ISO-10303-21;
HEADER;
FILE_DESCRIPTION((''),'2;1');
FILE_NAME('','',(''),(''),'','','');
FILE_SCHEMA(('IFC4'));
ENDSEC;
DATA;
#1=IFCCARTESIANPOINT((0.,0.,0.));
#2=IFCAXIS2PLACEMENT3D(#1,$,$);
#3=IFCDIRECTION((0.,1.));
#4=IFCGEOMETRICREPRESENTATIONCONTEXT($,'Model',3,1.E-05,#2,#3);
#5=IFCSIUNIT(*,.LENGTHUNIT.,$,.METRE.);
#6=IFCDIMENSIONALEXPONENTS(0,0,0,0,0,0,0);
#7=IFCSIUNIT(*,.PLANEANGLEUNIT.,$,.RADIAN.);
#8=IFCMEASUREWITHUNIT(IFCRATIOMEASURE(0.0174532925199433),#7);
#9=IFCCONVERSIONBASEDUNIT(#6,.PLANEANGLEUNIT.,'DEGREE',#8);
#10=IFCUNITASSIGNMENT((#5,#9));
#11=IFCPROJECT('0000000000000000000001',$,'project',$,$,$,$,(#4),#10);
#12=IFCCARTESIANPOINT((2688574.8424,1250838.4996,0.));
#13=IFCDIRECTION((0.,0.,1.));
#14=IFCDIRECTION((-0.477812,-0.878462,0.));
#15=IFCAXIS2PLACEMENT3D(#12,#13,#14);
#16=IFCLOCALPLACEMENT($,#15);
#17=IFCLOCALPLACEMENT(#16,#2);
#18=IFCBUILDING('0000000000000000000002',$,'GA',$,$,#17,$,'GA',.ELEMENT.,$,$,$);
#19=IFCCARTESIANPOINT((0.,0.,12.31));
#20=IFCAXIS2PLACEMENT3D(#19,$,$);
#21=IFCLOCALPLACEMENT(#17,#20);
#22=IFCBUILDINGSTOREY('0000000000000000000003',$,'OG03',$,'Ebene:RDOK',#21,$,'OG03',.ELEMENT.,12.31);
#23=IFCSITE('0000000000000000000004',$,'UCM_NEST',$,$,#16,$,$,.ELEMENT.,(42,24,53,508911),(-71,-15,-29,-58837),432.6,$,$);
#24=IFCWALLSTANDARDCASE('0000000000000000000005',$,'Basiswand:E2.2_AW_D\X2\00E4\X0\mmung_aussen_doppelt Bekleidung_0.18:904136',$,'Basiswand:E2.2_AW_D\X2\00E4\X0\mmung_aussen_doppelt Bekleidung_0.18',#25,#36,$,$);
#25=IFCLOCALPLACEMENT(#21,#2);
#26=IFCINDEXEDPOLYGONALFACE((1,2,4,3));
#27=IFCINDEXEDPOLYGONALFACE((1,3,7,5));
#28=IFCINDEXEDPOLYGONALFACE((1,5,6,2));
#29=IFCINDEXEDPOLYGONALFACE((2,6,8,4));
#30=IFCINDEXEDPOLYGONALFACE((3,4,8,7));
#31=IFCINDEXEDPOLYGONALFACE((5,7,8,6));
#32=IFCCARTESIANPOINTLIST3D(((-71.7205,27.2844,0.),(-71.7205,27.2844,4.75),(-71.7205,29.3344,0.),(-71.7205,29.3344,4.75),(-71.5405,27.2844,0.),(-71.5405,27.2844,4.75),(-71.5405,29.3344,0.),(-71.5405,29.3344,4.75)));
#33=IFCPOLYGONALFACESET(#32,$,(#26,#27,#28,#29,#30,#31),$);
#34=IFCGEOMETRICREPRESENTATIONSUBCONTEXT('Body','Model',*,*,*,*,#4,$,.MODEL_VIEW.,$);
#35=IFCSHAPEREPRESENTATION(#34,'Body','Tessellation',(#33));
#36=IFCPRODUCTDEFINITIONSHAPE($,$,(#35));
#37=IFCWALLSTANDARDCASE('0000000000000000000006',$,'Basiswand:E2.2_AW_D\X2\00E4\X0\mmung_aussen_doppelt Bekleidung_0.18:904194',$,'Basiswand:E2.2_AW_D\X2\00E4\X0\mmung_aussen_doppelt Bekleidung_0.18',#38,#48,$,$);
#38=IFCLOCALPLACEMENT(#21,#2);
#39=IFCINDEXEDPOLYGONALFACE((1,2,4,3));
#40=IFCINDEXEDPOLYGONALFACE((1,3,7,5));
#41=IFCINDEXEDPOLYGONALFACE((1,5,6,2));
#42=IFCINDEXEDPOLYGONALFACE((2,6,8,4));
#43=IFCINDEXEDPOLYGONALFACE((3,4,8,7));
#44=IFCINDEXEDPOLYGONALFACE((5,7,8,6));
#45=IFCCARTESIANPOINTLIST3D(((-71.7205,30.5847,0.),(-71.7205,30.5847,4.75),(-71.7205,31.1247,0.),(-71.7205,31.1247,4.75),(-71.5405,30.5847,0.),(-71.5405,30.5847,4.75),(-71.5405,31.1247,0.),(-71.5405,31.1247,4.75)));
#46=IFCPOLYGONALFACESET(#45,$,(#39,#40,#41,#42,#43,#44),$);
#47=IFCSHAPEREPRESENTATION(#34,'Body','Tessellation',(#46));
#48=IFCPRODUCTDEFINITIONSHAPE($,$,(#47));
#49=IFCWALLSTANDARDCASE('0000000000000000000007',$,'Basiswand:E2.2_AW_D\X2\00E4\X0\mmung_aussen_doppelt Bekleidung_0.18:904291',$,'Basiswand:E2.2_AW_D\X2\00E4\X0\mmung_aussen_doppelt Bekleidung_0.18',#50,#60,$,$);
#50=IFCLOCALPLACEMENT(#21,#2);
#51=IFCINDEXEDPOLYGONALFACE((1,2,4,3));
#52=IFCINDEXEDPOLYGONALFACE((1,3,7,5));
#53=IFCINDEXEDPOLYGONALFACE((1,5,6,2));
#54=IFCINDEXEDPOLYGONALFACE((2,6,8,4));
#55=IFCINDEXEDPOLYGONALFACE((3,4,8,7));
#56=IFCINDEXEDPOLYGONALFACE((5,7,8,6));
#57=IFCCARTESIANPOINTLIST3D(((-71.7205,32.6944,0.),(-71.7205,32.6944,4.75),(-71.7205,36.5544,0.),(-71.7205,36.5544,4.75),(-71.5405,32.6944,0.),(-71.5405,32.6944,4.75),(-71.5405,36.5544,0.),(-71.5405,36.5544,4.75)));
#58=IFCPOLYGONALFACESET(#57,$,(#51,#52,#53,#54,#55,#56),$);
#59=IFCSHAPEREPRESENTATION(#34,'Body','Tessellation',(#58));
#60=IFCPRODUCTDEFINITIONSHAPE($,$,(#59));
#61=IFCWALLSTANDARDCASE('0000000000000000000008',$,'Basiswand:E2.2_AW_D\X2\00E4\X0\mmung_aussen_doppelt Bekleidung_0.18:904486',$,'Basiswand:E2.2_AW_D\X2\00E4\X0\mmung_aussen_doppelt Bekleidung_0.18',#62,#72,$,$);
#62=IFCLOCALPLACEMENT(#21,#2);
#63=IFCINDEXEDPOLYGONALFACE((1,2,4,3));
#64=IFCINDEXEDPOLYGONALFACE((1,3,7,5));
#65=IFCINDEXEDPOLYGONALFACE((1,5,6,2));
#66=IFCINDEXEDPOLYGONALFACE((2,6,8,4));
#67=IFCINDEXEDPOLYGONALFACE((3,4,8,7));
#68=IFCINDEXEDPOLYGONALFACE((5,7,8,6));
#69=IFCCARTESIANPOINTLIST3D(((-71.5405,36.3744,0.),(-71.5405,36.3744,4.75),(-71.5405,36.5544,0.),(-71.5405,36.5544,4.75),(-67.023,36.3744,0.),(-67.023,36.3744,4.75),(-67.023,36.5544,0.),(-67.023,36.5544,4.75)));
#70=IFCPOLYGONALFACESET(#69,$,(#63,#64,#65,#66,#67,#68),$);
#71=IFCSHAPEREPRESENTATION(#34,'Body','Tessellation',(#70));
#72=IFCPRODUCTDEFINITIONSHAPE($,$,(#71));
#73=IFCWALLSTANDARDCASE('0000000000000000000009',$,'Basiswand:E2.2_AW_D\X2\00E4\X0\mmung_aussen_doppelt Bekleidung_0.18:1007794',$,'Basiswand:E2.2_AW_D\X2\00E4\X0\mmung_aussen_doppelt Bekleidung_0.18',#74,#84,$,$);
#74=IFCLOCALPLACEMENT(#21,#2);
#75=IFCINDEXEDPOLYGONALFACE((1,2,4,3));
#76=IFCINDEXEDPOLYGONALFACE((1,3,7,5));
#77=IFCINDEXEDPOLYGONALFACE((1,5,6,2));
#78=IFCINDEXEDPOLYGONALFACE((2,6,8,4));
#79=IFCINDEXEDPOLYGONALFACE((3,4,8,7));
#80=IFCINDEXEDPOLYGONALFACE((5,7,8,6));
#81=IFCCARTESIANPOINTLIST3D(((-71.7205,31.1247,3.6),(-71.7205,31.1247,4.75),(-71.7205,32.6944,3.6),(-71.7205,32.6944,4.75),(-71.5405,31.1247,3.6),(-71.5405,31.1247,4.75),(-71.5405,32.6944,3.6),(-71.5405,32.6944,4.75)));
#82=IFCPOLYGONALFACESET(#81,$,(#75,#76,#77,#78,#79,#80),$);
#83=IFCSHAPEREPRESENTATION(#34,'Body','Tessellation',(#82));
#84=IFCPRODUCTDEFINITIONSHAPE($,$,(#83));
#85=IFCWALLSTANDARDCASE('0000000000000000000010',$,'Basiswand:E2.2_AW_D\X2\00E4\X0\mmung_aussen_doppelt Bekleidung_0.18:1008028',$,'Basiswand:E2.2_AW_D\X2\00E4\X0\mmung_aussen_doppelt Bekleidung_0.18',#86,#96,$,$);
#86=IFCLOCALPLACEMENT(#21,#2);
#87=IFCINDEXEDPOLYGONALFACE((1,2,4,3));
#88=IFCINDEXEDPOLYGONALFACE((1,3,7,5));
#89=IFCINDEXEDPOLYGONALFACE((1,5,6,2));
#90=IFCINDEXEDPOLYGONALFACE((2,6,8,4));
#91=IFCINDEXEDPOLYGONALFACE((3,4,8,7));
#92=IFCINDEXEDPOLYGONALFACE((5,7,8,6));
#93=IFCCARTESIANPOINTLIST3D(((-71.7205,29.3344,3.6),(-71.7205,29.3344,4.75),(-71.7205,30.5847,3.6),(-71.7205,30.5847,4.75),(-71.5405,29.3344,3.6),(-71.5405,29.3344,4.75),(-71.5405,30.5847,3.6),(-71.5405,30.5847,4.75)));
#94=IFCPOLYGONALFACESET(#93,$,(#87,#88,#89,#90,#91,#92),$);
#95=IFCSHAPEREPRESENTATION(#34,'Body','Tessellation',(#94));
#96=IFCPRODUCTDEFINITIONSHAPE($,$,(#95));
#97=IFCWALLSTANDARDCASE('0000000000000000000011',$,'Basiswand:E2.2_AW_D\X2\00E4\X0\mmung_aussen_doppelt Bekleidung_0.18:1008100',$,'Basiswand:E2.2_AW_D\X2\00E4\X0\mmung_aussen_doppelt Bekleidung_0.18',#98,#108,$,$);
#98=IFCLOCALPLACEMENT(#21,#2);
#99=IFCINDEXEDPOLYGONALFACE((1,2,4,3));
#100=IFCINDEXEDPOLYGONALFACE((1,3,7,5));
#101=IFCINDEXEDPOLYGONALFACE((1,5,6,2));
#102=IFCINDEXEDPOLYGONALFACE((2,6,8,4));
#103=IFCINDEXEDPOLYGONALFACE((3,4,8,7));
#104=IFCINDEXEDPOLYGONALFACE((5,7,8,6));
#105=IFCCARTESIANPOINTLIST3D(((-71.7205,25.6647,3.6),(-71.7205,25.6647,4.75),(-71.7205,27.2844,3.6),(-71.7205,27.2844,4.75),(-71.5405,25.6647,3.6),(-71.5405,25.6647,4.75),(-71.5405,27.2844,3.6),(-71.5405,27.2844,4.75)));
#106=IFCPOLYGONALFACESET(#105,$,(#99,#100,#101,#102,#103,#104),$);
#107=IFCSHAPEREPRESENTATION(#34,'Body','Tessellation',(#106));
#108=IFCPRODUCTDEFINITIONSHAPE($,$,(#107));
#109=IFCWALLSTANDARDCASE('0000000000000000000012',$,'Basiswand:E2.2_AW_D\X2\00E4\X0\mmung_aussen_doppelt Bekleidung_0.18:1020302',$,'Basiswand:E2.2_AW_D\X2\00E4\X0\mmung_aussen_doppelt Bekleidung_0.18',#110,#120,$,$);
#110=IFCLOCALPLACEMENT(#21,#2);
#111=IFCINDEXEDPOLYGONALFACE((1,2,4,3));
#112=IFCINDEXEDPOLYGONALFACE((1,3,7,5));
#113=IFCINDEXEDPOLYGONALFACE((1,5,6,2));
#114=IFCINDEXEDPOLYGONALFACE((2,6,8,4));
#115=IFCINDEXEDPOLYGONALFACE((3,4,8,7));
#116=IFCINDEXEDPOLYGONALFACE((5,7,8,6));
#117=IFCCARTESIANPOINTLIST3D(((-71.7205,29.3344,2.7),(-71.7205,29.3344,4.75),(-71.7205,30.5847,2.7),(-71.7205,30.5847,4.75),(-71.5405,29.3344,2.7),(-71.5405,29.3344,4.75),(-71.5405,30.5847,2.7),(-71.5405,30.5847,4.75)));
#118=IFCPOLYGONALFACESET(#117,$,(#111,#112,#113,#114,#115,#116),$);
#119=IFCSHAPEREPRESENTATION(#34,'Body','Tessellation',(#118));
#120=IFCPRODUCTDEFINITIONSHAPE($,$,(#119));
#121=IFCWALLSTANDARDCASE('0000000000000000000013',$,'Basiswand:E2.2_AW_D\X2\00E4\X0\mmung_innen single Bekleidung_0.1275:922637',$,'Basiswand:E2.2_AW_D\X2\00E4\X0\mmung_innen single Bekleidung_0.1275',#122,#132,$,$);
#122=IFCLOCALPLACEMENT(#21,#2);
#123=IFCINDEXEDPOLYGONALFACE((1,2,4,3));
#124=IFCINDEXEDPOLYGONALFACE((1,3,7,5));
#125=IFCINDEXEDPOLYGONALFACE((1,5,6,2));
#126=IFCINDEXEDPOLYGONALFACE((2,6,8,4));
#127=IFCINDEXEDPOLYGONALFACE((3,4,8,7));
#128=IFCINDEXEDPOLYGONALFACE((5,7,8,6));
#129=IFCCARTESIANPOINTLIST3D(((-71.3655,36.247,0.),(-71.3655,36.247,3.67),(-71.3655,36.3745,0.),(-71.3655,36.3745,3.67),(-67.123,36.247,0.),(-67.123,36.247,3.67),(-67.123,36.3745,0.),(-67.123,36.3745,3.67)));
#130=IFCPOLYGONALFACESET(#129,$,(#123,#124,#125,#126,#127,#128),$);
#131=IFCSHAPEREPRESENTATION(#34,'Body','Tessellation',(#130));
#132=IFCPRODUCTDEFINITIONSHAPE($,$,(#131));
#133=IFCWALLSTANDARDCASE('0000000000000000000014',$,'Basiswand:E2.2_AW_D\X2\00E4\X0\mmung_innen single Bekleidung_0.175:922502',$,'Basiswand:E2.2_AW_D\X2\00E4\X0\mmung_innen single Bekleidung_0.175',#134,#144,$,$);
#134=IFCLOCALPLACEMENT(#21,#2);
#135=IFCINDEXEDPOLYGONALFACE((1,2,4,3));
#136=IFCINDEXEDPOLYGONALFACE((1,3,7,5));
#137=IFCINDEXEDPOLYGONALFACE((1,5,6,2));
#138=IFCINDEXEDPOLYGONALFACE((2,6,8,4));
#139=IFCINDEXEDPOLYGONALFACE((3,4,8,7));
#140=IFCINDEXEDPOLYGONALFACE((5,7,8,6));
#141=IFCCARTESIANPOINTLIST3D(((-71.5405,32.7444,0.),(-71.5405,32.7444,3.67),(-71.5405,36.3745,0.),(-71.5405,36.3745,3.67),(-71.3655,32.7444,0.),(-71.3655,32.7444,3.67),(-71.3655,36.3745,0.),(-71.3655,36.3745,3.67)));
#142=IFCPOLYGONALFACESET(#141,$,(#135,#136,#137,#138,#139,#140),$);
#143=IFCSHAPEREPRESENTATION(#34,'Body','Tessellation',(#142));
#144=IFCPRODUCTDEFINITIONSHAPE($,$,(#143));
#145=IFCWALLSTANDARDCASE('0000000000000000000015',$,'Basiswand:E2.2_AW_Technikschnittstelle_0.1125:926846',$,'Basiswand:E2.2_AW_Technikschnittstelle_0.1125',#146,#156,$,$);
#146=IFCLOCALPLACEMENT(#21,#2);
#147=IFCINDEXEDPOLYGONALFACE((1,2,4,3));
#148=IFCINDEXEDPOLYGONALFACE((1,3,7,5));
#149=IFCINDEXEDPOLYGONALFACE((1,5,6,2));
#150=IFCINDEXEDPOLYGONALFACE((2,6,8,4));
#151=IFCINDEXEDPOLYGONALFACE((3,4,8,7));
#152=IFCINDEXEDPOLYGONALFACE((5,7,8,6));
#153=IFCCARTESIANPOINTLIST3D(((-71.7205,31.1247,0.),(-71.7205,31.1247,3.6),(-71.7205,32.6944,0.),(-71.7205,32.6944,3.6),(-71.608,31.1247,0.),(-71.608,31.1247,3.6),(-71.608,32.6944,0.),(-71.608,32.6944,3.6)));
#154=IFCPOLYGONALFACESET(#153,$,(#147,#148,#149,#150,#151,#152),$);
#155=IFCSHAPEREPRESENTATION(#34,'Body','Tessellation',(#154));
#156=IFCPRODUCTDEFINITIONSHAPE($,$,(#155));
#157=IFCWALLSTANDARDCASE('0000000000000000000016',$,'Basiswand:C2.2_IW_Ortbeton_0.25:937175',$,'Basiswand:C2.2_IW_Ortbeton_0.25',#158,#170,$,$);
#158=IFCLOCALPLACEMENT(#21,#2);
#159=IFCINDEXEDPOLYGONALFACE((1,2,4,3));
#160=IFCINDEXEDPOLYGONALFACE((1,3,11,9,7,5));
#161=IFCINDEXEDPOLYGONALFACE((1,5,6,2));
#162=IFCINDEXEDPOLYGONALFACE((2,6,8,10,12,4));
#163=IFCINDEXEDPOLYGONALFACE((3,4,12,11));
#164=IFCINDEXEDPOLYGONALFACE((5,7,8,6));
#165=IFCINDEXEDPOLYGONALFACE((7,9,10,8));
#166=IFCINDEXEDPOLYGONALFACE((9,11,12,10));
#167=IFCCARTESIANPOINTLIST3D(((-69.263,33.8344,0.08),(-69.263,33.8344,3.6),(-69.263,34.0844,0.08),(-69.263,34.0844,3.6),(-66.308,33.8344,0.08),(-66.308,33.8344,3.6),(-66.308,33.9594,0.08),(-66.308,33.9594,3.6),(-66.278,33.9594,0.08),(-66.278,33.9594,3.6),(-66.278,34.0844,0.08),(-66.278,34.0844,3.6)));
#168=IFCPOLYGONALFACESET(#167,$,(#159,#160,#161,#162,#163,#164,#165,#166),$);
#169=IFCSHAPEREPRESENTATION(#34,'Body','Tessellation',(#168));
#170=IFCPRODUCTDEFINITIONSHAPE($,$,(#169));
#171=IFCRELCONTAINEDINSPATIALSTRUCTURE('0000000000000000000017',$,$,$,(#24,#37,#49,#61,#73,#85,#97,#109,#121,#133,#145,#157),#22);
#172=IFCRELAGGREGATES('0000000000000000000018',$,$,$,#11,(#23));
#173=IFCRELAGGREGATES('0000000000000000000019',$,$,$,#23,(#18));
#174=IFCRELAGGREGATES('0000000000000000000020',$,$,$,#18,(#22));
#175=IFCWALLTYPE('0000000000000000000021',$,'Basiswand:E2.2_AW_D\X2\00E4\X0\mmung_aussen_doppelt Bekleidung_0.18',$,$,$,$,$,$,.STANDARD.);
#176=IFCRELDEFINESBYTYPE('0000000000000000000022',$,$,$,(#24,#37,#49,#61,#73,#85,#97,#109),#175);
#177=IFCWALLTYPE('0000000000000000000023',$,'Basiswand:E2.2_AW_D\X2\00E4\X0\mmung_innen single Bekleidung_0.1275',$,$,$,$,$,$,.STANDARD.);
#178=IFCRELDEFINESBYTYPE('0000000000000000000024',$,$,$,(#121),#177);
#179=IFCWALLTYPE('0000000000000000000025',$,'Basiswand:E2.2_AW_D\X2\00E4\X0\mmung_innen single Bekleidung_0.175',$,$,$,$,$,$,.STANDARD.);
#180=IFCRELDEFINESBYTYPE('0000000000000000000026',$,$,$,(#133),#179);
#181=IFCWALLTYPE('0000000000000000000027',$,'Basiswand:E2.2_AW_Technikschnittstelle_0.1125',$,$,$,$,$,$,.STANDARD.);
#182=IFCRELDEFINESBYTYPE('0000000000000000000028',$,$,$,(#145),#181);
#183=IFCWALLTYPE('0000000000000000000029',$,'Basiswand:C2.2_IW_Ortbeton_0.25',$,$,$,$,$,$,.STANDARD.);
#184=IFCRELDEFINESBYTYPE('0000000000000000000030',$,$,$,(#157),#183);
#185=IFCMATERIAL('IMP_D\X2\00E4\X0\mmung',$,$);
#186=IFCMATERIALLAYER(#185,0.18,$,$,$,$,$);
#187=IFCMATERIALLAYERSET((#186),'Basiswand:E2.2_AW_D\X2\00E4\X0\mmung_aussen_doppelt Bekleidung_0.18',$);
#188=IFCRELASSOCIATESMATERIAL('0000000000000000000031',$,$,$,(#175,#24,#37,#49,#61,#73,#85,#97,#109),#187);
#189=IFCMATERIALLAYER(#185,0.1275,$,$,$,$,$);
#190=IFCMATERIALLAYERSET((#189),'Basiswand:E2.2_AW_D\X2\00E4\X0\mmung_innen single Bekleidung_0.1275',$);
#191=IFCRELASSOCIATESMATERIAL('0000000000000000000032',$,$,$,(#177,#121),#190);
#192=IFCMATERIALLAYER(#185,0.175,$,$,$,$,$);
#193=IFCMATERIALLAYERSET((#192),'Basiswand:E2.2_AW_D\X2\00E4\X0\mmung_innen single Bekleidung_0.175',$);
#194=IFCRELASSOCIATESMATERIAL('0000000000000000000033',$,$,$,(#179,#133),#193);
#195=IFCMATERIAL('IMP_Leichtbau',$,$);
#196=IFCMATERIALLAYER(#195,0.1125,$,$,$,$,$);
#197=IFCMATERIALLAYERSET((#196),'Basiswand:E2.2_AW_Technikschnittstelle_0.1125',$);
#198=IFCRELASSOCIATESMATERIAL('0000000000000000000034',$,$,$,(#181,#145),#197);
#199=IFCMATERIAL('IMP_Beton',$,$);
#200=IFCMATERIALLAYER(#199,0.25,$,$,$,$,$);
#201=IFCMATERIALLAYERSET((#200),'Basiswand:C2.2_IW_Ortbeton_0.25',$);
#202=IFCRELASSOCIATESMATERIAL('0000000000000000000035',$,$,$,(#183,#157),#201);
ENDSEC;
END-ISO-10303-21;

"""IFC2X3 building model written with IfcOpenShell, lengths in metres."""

from ifc_helpers import new_model, entity, si_unit, converted_unit, direction, frame, frame_2d, origin, place, context, subcontext, project, spatial, polyline, rectangle, outline, extrude, clip, bounded_halfspace, material, layer, layer_set, layer_usage, type_object, element, save


model = new_model("IFC2X3")

# Units and contexts
model_context = context("Model", 3, precision=1e-05, world=origin(), true_north=direction((0.0, 1.0)))
body_context = subcontext(model_context, "Body", "Model", "MODEL_VIEW")
ifc_project = project(units=[si_unit("LENGTHUNIT", "METRE"), converted_unit("PLANEANGLEUNIT", "DEGREE", entity("IfcRatioMeasure", 0.0174532925199433), si_unit("PLANEANGLEUNIT", "RADIAN"), dimensions=[0, 0, 0, 0, 0, 0, 0])], contexts=[model_context])

# Site, building, storey
site_placement = place(None, frame((2688574.8424, 1250838.4996, 0.0), z_axis=(0.0, 0.0, 1.0), x_axis=(-0.477812, -0.878462, 0.0)))
site = spatial("IfcSite", under=ifc_project, at=site_placement, Name="UCM_NEST", CompositionType="ELEMENT", RefLatitude=(42, 24, 53, 508911), RefLongitude=(-71, -15, -29, -58837), RefElevation=432.6)
building_placement = place(site_placement, origin())
building = spatial("IfcBuilding", under=site, at=building_placement, Name="GA", LongName="GA", CompositionType="ELEMENT")
storey_placement = place(building_placement, frame((0.0, 0.0, 12.31)))
storey = spatial("IfcBuildingStorey", under=building, at=storey_placement, Name="OG03", ObjectType="Ebene:RDOK", LongName="OG03", CompositionType="ELEMENT", Elevation=12.31)

# Walls
ifc_material_1 = material(Name="IMP_Dämmung")
ifc_layer_1 = layer(ifc_material_1, 0.18)
ifc_layer_set_1 = layer_set([ifc_layer_1], Name="Basiswand:E2.2_AW_Dämmung_aussen_doppelt Bekleidung_0.18")
ifc_layer_usage_1 = layer_usage(ifc_layer_set_1, "AXIS2", "NEGATIVE", 0.09)
wall_type_1 = type_object("IfcWallType", Name="Basiswand:E2.2_AW_Dämmung_aussen_doppelt Bekleidung_0.18", PredefinedType="STANDARD", material=ifc_layer_set_1)
wall_1_placement = place(storey_placement, frame((-71.6305, 27.2844, 0.0), z_axis=(0.0, 0.0, 1.0), x_axis=(0.0, 1.0, 0.0)))
element("IfcWallStandardCase", 1, at=wall_1_placement, inside=storey, type_object=wall_type_1, material=ifc_layer_usage_1, Name="Basiswand:E2.2_AW_Dämmung_aussen_doppelt Bekleidung_0.18:904136", ObjectType="Basiswand:E2.2_AW_Dämmung_aussen_doppelt Bekleidung_0.18", context=body_context, shape_type="SweptSolid", body=[
    extrude(rectangle(XDim=2.05, YDim=0.18, at=frame_2d((1.025, 0.0), x_axis=(-1.0, 0.0))), origin(), (0.0, 0.0, 1.0), 4.75),
])
ifc_layer_usage_2 = layer_usage(ifc_layer_set_1, "AXIS2", "NEGATIVE", 0.09)
wall_2_placement = place(storey_placement, frame((-71.6305, 30.5847, 0.0), z_axis=(0.0, 0.0, 1.0), x_axis=(0.0, 1.0, 0.0)))
element("IfcWallStandardCase", 2, at=wall_2_placement, inside=storey, type_object=wall_type_1, material=ifc_layer_usage_2, Name="Basiswand:E2.2_AW_Dämmung_aussen_doppelt Bekleidung_0.18:904194", ObjectType="Basiswand:E2.2_AW_Dämmung_aussen_doppelt Bekleidung_0.18", context=body_context, shape_type="SweptSolid", body=[
    extrude(rectangle(XDim=0.54, YDim=0.18, at=frame_2d((0.27, 0.0), x_axis=(-1.0, 0.0))), origin(), (0.0, 0.0, 1.0), 4.75),
])
ifc_layer_usage_3 = layer_usage(ifc_layer_set_1, "AXIS2", "NEGATIVE", 0.09)
wall_3_placement = place(storey_placement, frame((-71.6305, 32.6944, 0.0), z_axis=(0.0, 0.0, 1.0), x_axis=(0.0, 1.0, 0.0)))
element("IfcWallStandardCase", 3, at=wall_3_placement, inside=storey, type_object=wall_type_1, material=ifc_layer_usage_3, Name="Basiswand:E2.2_AW_Dämmung_aussen_doppelt Bekleidung_0.18:904291", ObjectType="Basiswand:E2.2_AW_Dämmung_aussen_doppelt Bekleidung_0.18", context=body_context, shape_type="SweptSolid", body=[
    extrude(rectangle(XDim=3.86, YDim=0.18, at=frame_2d((1.93, 0.0), x_axis=(-1.0, 0.0))), origin(), (0.0, 0.0, 1.0), 4.75),
])
ifc_layer_usage_4 = layer_usage(ifc_layer_set_1, "AXIS2", "NEGATIVE", 0.09)
wall_4_placement = place(storey_placement, frame((-71.5405, 36.4644, 0.0)))
element("IfcWallStandardCase", 4, at=wall_4_placement, inside=storey, type_object=wall_type_1, material=ifc_layer_usage_4, Name="Basiswand:E2.2_AW_Dämmung_aussen_doppelt Bekleidung_0.18:904486", ObjectType="Basiswand:E2.2_AW_Dämmung_aussen_doppelt Bekleidung_0.18", context=body_context, shape_type="SweptSolid", body=[
    extrude(rectangle(XDim=4.5175, YDim=0.18, at=frame_2d((2.2587, 0.0), x_axis=(-1.0, 0.0))), origin(), (0.0, 0.0, 1.0), 4.75),
])
ifc_layer_usage_5 = layer_usage(ifc_layer_set_1, "AXIS2", "NEGATIVE", 0.09)
wall_5_placement = place(storey_placement, frame((-71.6305, 32.6944, 3.6), z_axis=(0.0, 0.0, 1.0), x_axis=(0.0, -1.0, 0.0)))
element("IfcWallStandardCase", 5, at=wall_5_placement, inside=storey, type_object=wall_type_1, material=ifc_layer_usage_5, Name="Basiswand:E2.2_AW_Dämmung_aussen_doppelt Bekleidung_0.18:1007794", ObjectType="Basiswand:E2.2_AW_Dämmung_aussen_doppelt Bekleidung_0.18", context=body_context, shape_type="SweptSolid", body=[
    extrude(rectangle(XDim=1.5698, YDim=0.18, at=frame_2d((0.7849, 0.0), x_axis=(-1.0, 0.0))), origin(), (0.0, 0.0, 1.0), 1.15),
])
ifc_layer_usage_6 = layer_usage(ifc_layer_set_1, "AXIS2", "NEGATIVE", 0.09)
wall_6_placement = place(storey_placement, frame((-71.6305, 30.5847, 3.6), z_axis=(0.0, 0.0, 1.0), x_axis=(0.0, -1.0, 0.0)))
element("IfcWallStandardCase", 6, at=wall_6_placement, inside=storey, type_object=wall_type_1, material=ifc_layer_usage_6, Name="Basiswand:E2.2_AW_Dämmung_aussen_doppelt Bekleidung_0.18:1008028", ObjectType="Basiswand:E2.2_AW_Dämmung_aussen_doppelt Bekleidung_0.18", context=body_context, shape_type="SweptSolid", body=[
    extrude(rectangle(XDim=1.2502, YDim=0.18, at=frame_2d((0.6251, 0.0), x_axis=(-1.0, 0.0))), origin(), (0.0, 0.0, 1.0), 1.15),
])
ifc_layer_usage_7 = layer_usage(ifc_layer_set_1, "AXIS2", "NEGATIVE", 0.09)
wall_7_placement = place(storey_placement, frame((-71.6305, 27.2844, 3.6), z_axis=(0.0, 0.0, 1.0), x_axis=(0.0, -1.0, 0.0)))
element("IfcWallStandardCase", 7, at=wall_7_placement, inside=storey, type_object=wall_type_1, material=ifc_layer_usage_7, Name="Basiswand:E2.2_AW_Dämmung_aussen_doppelt Bekleidung_0.18:1008100", ObjectType="Basiswand:E2.2_AW_Dämmung_aussen_doppelt Bekleidung_0.18", context=body_context, shape_type="SweptSolid", body=[
    extrude(rectangle(XDim=1.6197, YDim=0.18, at=frame_2d((0.8099, 0.0), x_axis=(-1.0, 0.0))), origin(), (0.0, 0.0, 1.0), 1.15),
])
ifc_layer_usage_8 = layer_usage(ifc_layer_set_1, "AXIS2", "NEGATIVE", 0.09)
wall_8_placement = place(storey_placement, frame((-71.6305, 29.3344, 2.7), z_axis=(0.0, 0.0, 1.0), x_axis=(0.0, 1.0, 0.0)))
element("IfcWallStandardCase", 8, at=wall_8_placement, inside=storey, type_object=wall_type_1, material=ifc_layer_usage_8, Name="Basiswand:E2.2_AW_Dämmung_aussen_doppelt Bekleidung_0.18:1020302", ObjectType="Basiswand:E2.2_AW_Dämmung_aussen_doppelt Bekleidung_0.18", context=body_context, shape_type="SweptSolid", body=[
    extrude(rectangle(XDim=1.2502, YDim=0.18, at=frame_2d((0.6251, 0.0), x_axis=(-1.0, 0.0))), origin(), (0.0, 0.0, 1.0), 2.05),
])

# Shared definitions
ifc_material_2 = material(Name="IMP_Beton")

# Walls
ifc_layer_2 = layer(ifc_material_1, 0.1275)
ifc_layer_set_2 = layer_set([ifc_layer_2], Name="Basiswand:E2.2_AW_Dämmung_innen single Bekleidung_0.1275")
ifc_layer_usage_9 = layer_usage(ifc_layer_set_2, "AXIS2", "NEGATIVE", 0.0638)
wall_type_2 = type_object("IfcWallType", Name="Basiswand:E2.2_AW_Dämmung_innen single Bekleidung_0.1275", PredefinedType="STANDARD", material=ifc_layer_set_2)
wall_9_placement = place(storey_placement, frame((-71.3655, 36.3107, 0.0)))
element("IfcWallStandardCase", 9, at=wall_9_placement, inside=storey, type_object=wall_type_2, material=ifc_layer_usage_9, Name="Basiswand:E2.2_AW_Dämmung_innen single Bekleidung_0.1275:922637", ObjectType="Basiswand:E2.2_AW_Dämmung_innen single Bekleidung_0.1275", context=body_context, shape_type="SweptSolid", body=[
    extrude(rectangle(XDim=4.2425, YDim=0.1275, at=frame_2d((2.1212, 0.0), x_axis=(-1.0, 0.0))), origin(), (0.0, 0.0, 1.0), 3.67),
])
ifc_layer_3 = layer(ifc_material_1, 0.175)
ifc_layer_set_3 = layer_set([ifc_layer_3], Name="Basiswand:E2.2_AW_Dämmung_innen single Bekleidung_0.175")
ifc_layer_usage_10 = layer_usage(ifc_layer_set_3, "AXIS2", "NEGATIVE", 0.0875)
wall_type_3 = type_object("IfcWallType", Name="Basiswand:E2.2_AW_Dämmung_innen single Bekleidung_0.175", PredefinedType="STANDARD", material=ifc_layer_set_3)
wall_10_placement = place(storey_placement, frame((-71.453, 32.7444, 0.0), z_axis=(0.0, 0.0, 1.0), x_axis=(0.0, 1.0, 0.0)))
element("IfcWallStandardCase", 10, at=wall_10_placement, inside=storey, type_object=wall_type_3, material=ifc_layer_usage_10, Name="Basiswand:E2.2_AW_Dämmung_innen single Bekleidung_0.175:922502", ObjectType="Basiswand:E2.2_AW_Dämmung_innen single Bekleidung_0.175", context=body_context, shape_type="SweptSolid", body=[
    extrude(rectangle(XDim=3.63, YDim=0.175, at=frame_2d((1.815, 0.0), x_axis=(-1.0, 0.0))), origin(), (0.0, 0.0, 1.0), 3.67),
])
ifc_material_3 = material(Name="IMP_Leichtbau")
ifc_layer_4 = layer(ifc_material_3, 0.1125)
ifc_layer_set_4 = layer_set([ifc_layer_4], Name="Basiswand:E2.2_AW_Technikschnittstelle_0.1125")
ifc_layer_usage_11 = layer_usage(ifc_layer_set_4, "AXIS2", "NEGATIVE", 0.0563)
wall_type_4 = type_object("IfcWallType", Name="Basiswand:E2.2_AW_Technikschnittstelle_0.1125", PredefinedType="STANDARD", material=ifc_layer_set_4)
wall_11_placement = place(storey_placement, frame((-71.6642, 31.1247, 0.0), z_axis=(0.0, 0.0, 1.0), x_axis=(0.0, 1.0, 0.0)))
element("IfcWallStandardCase", 11, at=wall_11_placement, inside=storey, type_object=wall_type_4, material=ifc_layer_usage_11, Name="Basiswand:E2.2_AW_Technikschnittstelle_0.1125:926846", ObjectType="Basiswand:E2.2_AW_Technikschnittstelle_0.1125", context=body_context, shape_type="SweptSolid", body=[
    extrude(rectangle(XDim=1.5698, YDim=0.1125, at=frame_2d((0.7849, 0.0), x_axis=(-1.0, 0.0))), origin(), (0.0, 0.0, 1.0), 3.6),
])
ifc_layer_5 = layer(ifc_material_2, 0.25)
ifc_layer_set_5 = layer_set([ifc_layer_5], Name="Basiswand:C2.2_IW_Ortbeton_0.25")
ifc_layer_usage_12 = layer_usage(ifc_layer_set_5, "AXIS2", "NEGATIVE", 0.125)
wall_type_5 = type_object("IfcWallType", Name="Basiswand:C2.2_IW_Ortbeton_0.25", PredefinedType="STANDARD", material=ifc_layer_set_5)
wall_12_placement = place(storey_placement, frame((-69.263, 33.9594, 0.08)))
element("IfcWallStandardCase", 12, at=wall_12_placement, inside=storey, type_object=wall_type_5, material=ifc_layer_usage_12, Name="Basiswand:C2.2_IW_Ortbeton_0.25:937175", ObjectType="Basiswand:C2.2_IW_Ortbeton_0.25", context=body_context, shape_type="Clipping", body=[
    clip(extrude(outline(polyline([(0.0, -0.125), (2.02, -0.125), (2.2, -0.125), (2.955, -0.125), (2.955, 0.0), (2.985, 0.0), (2.985, 0.125), (0.0, 0.125), (0.0, -0.125)])), origin(), (0.0, 0.0, 1.0), 3.52), bounded_halfspace(frame((2.955, -0.125, 0.0), z_axis=(0.0, 0.0, 1.0), x_axis=(-1.0, 0.0, 0.0)), True, frame((2.955, -0.125, 0.0), z_axis=(0.0, 0.0, 1.0), x_axis=(-1.0, 0.0, 0.0)), polyline([(0.0, 0.0), (0.0, -0.125), (-0.03, -0.125), (-0.03, -0.25), (2.955, -0.25), (2.955, 0.0), (0.935, 0.0), (0.755, 0.0), (0.0, 0.0)]))),
])

save(model, "model.ifc")
